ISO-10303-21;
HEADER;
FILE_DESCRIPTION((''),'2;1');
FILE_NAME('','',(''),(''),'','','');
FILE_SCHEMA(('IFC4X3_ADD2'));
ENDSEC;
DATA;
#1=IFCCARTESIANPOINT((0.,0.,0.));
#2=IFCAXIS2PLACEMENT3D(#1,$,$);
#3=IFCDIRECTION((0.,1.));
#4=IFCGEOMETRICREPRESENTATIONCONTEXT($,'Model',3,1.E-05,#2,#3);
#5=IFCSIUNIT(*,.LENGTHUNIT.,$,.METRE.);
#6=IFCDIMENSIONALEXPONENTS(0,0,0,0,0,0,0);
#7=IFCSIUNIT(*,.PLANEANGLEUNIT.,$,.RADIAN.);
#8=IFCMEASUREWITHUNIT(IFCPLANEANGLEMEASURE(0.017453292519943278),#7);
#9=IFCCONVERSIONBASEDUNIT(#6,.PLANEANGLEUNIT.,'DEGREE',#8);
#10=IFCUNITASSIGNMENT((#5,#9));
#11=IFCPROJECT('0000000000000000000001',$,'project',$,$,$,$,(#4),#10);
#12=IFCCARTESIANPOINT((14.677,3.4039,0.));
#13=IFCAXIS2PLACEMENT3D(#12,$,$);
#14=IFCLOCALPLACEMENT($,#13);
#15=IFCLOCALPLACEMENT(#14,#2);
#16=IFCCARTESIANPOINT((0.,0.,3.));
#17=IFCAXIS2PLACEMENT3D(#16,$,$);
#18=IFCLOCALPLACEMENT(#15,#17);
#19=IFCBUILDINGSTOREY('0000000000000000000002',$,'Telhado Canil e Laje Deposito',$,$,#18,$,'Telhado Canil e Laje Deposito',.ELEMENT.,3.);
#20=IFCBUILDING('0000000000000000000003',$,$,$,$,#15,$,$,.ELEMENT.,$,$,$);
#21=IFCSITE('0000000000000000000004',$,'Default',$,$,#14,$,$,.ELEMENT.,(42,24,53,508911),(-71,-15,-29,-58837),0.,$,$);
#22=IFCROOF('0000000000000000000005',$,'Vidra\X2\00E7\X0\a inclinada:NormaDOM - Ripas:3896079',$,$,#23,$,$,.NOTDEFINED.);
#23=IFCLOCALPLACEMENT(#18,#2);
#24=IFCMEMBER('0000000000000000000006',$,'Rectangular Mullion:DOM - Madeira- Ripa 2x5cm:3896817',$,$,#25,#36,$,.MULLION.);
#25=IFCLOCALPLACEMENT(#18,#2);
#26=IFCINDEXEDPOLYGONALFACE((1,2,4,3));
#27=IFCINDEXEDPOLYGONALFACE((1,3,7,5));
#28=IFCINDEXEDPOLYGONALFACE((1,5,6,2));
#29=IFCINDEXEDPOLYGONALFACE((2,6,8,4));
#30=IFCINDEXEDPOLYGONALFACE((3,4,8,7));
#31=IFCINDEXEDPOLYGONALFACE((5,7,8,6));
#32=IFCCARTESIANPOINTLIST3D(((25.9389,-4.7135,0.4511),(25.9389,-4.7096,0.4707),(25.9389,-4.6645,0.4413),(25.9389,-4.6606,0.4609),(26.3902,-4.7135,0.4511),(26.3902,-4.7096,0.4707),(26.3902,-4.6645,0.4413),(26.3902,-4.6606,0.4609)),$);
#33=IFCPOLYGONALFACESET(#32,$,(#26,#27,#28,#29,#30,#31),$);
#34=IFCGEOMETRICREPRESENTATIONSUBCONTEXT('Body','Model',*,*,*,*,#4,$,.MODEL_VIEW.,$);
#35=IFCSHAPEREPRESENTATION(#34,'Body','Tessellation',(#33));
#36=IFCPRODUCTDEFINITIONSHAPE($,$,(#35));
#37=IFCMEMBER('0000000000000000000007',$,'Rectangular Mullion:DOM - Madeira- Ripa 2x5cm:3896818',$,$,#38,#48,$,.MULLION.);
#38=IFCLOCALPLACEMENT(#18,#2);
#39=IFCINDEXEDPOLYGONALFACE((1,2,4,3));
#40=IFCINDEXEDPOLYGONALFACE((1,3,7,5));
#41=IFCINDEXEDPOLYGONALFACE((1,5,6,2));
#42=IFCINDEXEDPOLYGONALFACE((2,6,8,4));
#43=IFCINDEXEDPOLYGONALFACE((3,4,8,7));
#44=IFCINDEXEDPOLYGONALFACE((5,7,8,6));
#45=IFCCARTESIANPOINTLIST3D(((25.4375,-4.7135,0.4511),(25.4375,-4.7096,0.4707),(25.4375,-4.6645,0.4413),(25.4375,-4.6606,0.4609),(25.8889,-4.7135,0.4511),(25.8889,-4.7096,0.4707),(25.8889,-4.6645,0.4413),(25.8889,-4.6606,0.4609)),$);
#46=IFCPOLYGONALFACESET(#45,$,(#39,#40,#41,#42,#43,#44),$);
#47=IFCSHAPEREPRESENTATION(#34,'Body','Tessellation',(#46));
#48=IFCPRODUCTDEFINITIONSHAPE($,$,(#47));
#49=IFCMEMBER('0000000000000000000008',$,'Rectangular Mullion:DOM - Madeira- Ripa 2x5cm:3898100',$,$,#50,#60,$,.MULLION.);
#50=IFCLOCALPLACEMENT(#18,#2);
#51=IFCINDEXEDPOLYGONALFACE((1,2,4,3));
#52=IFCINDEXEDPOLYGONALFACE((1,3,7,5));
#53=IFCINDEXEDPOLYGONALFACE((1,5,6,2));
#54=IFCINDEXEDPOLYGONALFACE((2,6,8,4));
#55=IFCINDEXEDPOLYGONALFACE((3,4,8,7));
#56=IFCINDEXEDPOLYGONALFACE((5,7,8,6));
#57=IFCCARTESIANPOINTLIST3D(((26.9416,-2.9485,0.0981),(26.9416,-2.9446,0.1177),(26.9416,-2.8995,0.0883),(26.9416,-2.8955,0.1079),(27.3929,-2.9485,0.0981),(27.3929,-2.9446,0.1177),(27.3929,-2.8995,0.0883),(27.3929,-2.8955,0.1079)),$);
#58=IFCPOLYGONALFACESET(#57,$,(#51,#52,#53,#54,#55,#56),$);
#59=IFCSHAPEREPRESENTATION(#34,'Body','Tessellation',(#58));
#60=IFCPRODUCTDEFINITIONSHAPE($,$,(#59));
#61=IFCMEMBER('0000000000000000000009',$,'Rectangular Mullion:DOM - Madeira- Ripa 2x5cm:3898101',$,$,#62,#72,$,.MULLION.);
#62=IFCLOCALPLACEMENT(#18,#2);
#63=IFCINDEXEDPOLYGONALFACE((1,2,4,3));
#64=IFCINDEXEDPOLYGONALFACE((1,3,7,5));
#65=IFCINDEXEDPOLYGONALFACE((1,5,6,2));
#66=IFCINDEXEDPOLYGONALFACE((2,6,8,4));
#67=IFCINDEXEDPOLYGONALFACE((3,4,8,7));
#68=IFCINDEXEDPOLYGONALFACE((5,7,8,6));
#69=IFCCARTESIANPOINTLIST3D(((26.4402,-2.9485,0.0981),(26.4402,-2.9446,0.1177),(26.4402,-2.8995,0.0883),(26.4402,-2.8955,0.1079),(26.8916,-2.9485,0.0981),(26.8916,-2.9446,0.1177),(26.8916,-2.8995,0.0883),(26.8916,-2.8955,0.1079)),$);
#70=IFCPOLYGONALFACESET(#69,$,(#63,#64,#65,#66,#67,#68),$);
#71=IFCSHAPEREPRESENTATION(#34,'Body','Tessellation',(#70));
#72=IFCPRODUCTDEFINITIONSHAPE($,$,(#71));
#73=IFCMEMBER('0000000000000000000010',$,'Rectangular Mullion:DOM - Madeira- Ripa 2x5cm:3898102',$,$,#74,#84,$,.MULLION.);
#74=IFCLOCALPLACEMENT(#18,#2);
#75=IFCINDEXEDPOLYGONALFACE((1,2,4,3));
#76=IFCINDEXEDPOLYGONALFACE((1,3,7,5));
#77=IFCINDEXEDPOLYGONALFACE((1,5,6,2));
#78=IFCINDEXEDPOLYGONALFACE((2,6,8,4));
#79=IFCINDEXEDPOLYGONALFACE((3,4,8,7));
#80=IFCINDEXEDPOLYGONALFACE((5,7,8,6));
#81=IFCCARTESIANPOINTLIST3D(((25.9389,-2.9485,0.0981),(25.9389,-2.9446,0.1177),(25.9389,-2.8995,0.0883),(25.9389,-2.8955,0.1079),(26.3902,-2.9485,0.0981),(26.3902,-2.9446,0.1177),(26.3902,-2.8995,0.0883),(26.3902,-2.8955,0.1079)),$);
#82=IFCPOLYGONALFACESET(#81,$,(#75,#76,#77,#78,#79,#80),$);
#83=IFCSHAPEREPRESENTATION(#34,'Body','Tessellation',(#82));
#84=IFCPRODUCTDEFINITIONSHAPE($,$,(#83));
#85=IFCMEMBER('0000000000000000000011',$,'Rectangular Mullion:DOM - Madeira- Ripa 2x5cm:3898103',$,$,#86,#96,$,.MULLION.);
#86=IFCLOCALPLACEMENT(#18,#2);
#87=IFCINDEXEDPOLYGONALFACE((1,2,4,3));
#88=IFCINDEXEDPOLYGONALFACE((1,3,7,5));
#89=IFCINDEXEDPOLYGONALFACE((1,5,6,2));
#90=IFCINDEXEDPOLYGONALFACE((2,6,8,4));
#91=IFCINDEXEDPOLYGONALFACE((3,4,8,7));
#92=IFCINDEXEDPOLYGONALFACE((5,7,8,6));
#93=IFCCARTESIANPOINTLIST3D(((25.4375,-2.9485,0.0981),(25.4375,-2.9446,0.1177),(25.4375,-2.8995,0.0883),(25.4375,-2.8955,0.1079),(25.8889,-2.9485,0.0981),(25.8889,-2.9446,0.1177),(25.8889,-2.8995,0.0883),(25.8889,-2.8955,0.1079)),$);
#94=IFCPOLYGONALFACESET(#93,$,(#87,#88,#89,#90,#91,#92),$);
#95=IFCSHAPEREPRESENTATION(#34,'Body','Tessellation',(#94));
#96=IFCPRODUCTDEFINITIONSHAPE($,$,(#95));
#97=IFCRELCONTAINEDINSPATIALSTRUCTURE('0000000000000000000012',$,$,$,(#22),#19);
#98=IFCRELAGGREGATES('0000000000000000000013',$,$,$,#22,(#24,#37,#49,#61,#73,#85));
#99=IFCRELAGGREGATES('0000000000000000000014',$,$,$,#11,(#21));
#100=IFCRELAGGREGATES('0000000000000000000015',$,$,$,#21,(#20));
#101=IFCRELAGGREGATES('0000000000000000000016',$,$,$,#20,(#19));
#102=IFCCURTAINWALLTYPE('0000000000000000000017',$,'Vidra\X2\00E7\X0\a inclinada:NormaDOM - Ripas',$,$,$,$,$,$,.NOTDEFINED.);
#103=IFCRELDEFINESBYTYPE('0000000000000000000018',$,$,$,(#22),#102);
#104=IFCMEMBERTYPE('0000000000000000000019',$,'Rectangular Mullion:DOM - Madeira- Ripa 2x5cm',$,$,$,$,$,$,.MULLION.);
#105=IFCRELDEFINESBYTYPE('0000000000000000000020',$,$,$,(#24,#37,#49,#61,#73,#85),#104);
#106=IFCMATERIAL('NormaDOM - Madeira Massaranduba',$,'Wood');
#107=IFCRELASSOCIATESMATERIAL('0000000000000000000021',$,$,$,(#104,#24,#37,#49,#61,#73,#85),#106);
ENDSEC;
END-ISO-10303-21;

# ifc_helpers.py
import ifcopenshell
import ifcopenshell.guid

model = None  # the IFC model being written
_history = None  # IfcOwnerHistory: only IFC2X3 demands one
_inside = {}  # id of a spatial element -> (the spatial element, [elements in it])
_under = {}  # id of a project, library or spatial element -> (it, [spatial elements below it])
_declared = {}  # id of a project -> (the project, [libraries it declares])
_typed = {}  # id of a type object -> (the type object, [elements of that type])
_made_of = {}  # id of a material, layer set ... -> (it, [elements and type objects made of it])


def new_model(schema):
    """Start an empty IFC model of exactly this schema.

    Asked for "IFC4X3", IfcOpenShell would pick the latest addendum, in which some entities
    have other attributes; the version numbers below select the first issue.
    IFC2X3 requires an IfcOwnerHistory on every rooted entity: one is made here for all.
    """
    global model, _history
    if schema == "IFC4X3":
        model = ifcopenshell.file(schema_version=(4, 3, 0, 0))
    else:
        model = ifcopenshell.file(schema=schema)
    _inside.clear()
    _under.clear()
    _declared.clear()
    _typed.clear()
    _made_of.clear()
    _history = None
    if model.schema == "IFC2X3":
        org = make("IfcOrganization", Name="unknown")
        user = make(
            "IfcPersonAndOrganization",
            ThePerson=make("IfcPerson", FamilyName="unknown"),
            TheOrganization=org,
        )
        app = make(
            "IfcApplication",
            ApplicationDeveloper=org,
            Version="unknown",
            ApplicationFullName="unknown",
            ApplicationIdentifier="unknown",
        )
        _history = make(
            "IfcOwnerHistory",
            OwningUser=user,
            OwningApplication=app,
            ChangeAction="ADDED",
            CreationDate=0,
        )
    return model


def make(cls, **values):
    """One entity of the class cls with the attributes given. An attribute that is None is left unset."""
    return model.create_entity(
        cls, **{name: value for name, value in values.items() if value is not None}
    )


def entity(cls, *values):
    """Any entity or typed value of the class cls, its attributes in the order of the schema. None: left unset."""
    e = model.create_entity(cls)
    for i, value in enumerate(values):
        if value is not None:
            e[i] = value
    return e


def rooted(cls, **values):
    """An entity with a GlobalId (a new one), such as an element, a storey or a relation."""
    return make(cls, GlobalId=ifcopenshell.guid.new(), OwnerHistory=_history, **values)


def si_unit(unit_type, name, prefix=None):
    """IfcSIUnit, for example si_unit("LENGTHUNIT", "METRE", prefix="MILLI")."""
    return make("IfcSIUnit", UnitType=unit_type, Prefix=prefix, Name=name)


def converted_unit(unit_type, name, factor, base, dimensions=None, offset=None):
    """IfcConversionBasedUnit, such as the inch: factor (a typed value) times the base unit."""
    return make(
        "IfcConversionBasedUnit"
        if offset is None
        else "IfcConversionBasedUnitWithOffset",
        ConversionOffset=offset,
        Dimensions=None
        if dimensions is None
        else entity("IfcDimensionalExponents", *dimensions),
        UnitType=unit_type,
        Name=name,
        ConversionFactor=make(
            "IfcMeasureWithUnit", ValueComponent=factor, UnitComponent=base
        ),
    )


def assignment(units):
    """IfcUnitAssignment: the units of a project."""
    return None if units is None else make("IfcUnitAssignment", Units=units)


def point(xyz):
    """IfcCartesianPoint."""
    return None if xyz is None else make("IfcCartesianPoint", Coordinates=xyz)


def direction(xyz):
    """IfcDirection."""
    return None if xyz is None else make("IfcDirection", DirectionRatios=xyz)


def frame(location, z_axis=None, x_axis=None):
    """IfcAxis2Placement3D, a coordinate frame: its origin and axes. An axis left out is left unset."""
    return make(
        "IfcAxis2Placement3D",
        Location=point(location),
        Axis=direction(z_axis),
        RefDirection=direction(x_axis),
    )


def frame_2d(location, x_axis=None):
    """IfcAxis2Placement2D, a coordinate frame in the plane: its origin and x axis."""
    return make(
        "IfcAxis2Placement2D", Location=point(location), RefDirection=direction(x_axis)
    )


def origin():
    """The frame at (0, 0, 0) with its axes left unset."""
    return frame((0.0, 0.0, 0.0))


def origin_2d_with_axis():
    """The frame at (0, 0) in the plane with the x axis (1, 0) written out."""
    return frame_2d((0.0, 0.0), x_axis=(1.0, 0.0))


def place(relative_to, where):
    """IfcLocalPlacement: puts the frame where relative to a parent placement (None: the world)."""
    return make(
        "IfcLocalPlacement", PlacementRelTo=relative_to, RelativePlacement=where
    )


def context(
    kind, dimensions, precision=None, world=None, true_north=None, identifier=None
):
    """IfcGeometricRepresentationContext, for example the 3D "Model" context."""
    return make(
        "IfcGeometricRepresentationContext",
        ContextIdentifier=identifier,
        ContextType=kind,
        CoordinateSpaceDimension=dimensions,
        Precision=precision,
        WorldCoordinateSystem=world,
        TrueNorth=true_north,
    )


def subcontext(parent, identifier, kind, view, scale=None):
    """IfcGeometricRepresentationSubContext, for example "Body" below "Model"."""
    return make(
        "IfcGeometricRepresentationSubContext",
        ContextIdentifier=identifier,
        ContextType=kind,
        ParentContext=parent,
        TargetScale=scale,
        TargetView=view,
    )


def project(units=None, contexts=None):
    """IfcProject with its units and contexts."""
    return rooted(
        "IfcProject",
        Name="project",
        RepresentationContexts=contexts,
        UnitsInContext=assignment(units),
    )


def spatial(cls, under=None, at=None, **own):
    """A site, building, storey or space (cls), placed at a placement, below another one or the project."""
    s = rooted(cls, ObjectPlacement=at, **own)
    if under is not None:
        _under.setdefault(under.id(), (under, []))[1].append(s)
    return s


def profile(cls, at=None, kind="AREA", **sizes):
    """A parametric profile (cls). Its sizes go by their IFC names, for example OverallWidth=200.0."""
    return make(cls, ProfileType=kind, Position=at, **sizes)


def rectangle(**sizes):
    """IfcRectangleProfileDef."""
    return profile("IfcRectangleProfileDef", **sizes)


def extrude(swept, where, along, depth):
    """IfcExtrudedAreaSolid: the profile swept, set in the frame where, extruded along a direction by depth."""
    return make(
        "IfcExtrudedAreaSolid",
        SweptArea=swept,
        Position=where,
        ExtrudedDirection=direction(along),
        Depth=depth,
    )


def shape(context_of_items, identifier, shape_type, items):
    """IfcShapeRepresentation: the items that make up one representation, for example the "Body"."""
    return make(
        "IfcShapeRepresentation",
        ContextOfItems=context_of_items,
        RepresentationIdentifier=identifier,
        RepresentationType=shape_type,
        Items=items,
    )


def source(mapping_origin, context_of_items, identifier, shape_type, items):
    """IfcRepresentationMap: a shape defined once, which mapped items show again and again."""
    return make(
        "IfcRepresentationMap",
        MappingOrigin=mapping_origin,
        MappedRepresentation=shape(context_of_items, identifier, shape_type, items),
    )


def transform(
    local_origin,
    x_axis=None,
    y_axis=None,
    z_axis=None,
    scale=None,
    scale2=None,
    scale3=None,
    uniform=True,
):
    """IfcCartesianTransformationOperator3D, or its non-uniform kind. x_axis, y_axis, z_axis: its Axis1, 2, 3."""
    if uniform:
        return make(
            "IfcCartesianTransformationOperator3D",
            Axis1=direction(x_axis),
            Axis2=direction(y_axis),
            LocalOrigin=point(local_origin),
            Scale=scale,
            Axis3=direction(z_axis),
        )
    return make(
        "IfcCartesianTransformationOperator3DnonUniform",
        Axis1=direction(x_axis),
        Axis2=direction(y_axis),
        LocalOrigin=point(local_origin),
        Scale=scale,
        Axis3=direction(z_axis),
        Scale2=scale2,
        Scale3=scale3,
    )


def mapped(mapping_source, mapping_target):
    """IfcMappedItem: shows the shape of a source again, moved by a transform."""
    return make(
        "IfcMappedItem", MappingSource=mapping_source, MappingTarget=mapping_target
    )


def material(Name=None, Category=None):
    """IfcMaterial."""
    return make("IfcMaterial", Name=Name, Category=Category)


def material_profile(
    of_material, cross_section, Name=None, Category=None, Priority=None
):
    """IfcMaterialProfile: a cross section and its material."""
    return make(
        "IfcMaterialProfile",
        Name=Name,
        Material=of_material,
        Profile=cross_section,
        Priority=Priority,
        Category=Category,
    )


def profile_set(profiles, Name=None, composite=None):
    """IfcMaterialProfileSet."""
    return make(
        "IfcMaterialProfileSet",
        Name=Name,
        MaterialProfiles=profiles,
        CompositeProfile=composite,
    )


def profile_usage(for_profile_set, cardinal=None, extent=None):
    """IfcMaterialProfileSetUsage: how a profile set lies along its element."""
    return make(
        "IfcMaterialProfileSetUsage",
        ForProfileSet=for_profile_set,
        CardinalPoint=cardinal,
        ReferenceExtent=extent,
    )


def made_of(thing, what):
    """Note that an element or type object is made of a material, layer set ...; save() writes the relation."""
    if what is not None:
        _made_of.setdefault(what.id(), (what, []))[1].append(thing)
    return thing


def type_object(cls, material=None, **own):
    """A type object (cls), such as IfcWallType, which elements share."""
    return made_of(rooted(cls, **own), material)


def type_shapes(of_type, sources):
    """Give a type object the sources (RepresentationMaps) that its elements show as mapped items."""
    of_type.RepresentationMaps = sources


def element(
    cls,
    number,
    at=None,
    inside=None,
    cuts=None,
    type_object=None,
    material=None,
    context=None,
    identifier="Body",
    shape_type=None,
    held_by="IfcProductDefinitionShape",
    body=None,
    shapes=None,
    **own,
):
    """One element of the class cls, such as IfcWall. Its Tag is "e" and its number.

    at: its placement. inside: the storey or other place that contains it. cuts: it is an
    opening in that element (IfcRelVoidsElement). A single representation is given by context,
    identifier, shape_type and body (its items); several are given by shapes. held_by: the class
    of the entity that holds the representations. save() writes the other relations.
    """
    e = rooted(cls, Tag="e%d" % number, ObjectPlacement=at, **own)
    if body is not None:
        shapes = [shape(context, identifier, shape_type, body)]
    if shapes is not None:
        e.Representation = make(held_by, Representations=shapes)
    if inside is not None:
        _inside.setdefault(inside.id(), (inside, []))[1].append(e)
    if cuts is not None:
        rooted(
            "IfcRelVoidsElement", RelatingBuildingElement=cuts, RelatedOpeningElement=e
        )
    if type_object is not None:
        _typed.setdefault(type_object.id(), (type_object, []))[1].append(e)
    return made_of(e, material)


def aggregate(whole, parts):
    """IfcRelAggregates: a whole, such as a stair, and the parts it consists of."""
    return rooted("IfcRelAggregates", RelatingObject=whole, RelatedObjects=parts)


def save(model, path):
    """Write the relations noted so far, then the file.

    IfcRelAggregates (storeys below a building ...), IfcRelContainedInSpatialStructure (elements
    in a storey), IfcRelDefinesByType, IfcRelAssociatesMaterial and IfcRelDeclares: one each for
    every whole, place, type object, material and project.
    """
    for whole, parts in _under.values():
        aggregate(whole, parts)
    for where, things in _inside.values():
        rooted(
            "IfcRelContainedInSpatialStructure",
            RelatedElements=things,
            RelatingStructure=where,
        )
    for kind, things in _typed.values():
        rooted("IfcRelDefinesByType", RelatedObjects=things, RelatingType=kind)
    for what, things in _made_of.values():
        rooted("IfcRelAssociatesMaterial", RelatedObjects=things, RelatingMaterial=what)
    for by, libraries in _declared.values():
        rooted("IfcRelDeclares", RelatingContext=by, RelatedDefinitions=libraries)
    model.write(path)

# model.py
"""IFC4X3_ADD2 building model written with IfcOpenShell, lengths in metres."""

from ifc_helpers import new_model, entity, si_unit, converted_unit, direction, frame, origin, origin_2d_with_axis, place, context, subcontext, project, spatial, rectangle, extrude, source, transform, mapped, material, material_profile, profile_set, profile_usage, type_object, type_shapes, element, aggregate, save


model = new_model("IFC4X3_ADD2")

# Units and contexts
model_context = context("Model", 3, precision=1e-05, world=origin(), true_north=direction((0.0, 1.0)))
body_context = subcontext(model_context, "Body", "Model", "MODEL_VIEW")
ifc_project = project(units=[si_unit("LENGTHUNIT", "METRE"), converted_unit("PLANEANGLEUNIT", "DEGREE", entity("IfcPlaneAngleMeasure", 0.017453292519943278), si_unit("PLANEANGLEUNIT", "RADIAN"), dimensions=[0, 0, 0, 0, 0, 0, 0])], contexts=[model_context])

# Site, building, storey
site_placement = place(None, frame((14.677, 3.4039, 0.0)))
site = spatial("IfcSite", under=ifc_project, at=site_placement, Name="Default", CompositionType="ELEMENT", RefLatitude=(42, 24, 53, 508911), RefLongitude=(-71, -15, -29, -58837), RefElevation=0.0)
building_placement = place(site_placement, origin())
building = spatial("IfcBuilding", under=site, at=building_placement, CompositionType="ELEMENT")
storey_placement = place(building_placement, frame((0.0, 0.0, 3.0)))
storey = spatial("IfcBuildingStorey", under=building, at=storey_placement, Name="Telhado Canil e Laje Deposito", LongName="Telhado Canil e Laje Deposito", CompositionType="ELEMENT", Elevation=3.0)

# Roof
ifc_material = material(Name="NormaDOM - Madeira Massaranduba", Category="Wood")
ifc_material_profile_1 = material_profile(ifc_material, rectangle(XDim=0.05, YDim=0.02, at=origin_2d_with_axis()), Name="DOM - Madeira- Ripa 2x5cm")
ifc_profile_set_1 = profile_set([ifc_material_profile_1], Name="DOM - Madeira- Ripa 2x5cm")
ifc_profile_usage_1 = profile_usage(ifc_profile_set_1)
curtain_wall_type_1 = type_object("IfcCurtainWallType", Name="Vidraça inclinada:NormaDOM - Ripas", PredefinedType="NOTDEFINED")
roof_1_placement = place(storey_placement, frame((0.0, 0.0, -3.0)))
roof_1 = element("IfcRoof", 1, at=roof_1_placement, inside=storey, type_object=curtain_wall_type_1, Name="Vidraça inclinada:NormaDOM - Ripas:3896079", PredefinedType="NOTDEFINED")

# Members
member_type_1 = type_object("IfcMemberType", Name="Rectangular Mullion:DOM - Madeira- Ripa 2x5cm", PredefinedType="MULLION", material=ifc_profile_set_1)
shared_shape_1 = source(origin(), body_context, "Body", "SweptSolid", [
    extrude(rectangle(XDim=0.05, YDim=0.02, at=origin_2d_with_axis()), frame((0.025, 0.01, -0.4514), z_axis=(0.0, 0.0, 1.0), x_axis=(-1.0, 0.0, 0.0)), (0.0, 0.0, 1.0), 0.4514),
])
type_shapes(member_type_1, [shared_shape_1])
member_1_placement = place(roof_1_placement, frame((26.3902, -4.6606, 3.4609), z_axis=(1.0, 0.0, 0.0), x_axis=(0.0, -0.980581, 0.196116)))
member_1 = element("IfcMember", 2, at=member_1_placement, type_object=member_type_1, material=ifc_profile_usage_1, Name="Rectangular Mullion:DOM - Madeira- Ripa 2x5cm:3896817", PredefinedType="MULLION", context=body_context, shape_type="MappedRepresentation", body=[
    mapped(shared_shape_1, transform((0.0, 0.0, 0.0), scale=1.0)),
])
member_2_placement = place(roof_1_placement, frame((25.8889, -4.6606, 3.4609), z_axis=(1.0, 0.0, 0.0), x_axis=(0.0, -0.980581, 0.196116)))
member_2 = element("IfcMember", 3, at=member_2_placement, type_object=member_type_1, material=ifc_profile_usage_1, Name="Rectangular Mullion:DOM - Madeira- Ripa 2x5cm:3896818", PredefinedType="MULLION", context=body_context, shape_type="MappedRepresentation", body=[
    mapped(shared_shape_1, transform((0.0, 0.0, 0.0), scale=1.0)),
])
member_3_placement = place(roof_1_placement, frame((27.3929, -2.8955, 3.1079), z_axis=(1.0, 0.0, 0.0), x_axis=(0.0, -0.980581, 0.196116)))
member_3 = element("IfcMember", 4, at=member_3_placement, type_object=member_type_1, material=ifc_profile_usage_1, Name="Rectangular Mullion:DOM - Madeira- Ripa 2x5cm:3898100", PredefinedType="MULLION", context=body_context, shape_type="MappedRepresentation", body=[
    mapped(shared_shape_1, transform((0.0, 0.0, 0.0), scale=1.0)),
])
member_4_placement = place(roof_1_placement, frame((26.8916, -2.8955, 3.1079), z_axis=(1.0, 0.0, 0.0), x_axis=(0.0, -0.980581, 0.196116)))
member_4 = element("IfcMember", 5, at=member_4_placement, type_object=member_type_1, material=ifc_profile_usage_1, Name="Rectangular Mullion:DOM - Madeira- Ripa 2x5cm:3898101", PredefinedType="MULLION", context=body_context, shape_type="MappedRepresentation", body=[
    mapped(shared_shape_1, transform((0.0, 0.0, 0.0), scale=1.0)),
])
member_5_placement = place(roof_1_placement, frame((26.3902, -2.8955, 3.1079), z_axis=(1.0, 0.0, 0.0), x_axis=(0.0, -0.980581, 0.196116)))
member_5 = element("IfcMember", 6, at=member_5_placement, type_object=member_type_1, material=ifc_profile_usage_1, Name="Rectangular Mullion:DOM - Madeira- Ripa 2x5cm:3898102", PredefinedType="MULLION", context=body_context, shape_type="MappedRepresentation", body=[
    mapped(shared_shape_1, transform((0.0, 0.0, 0.0), scale=1.0)),
])
member_6_placement = place(roof_1_placement, frame((25.8889, -2.8955, 3.1079), z_axis=(1.0, 0.0, 0.0), x_axis=(0.0, -0.980581, 0.196116)))
member_6 = element("IfcMember", 7, at=member_6_placement, type_object=member_type_1, material=ifc_profile_usage_1, Name="Rectangular Mullion:DOM - Madeira- Ripa 2x5cm:3898103", PredefinedType="MULLION", context=body_context, shape_type="MappedRepresentation", body=[
    mapped(shared_shape_1, transform((0.0, 0.0, 0.0), scale=1.0)),
])
aggregate(roof_1, [member_1, member_2, member_3, member_4, member_5, member_6])

save(model, "model.ifc")
